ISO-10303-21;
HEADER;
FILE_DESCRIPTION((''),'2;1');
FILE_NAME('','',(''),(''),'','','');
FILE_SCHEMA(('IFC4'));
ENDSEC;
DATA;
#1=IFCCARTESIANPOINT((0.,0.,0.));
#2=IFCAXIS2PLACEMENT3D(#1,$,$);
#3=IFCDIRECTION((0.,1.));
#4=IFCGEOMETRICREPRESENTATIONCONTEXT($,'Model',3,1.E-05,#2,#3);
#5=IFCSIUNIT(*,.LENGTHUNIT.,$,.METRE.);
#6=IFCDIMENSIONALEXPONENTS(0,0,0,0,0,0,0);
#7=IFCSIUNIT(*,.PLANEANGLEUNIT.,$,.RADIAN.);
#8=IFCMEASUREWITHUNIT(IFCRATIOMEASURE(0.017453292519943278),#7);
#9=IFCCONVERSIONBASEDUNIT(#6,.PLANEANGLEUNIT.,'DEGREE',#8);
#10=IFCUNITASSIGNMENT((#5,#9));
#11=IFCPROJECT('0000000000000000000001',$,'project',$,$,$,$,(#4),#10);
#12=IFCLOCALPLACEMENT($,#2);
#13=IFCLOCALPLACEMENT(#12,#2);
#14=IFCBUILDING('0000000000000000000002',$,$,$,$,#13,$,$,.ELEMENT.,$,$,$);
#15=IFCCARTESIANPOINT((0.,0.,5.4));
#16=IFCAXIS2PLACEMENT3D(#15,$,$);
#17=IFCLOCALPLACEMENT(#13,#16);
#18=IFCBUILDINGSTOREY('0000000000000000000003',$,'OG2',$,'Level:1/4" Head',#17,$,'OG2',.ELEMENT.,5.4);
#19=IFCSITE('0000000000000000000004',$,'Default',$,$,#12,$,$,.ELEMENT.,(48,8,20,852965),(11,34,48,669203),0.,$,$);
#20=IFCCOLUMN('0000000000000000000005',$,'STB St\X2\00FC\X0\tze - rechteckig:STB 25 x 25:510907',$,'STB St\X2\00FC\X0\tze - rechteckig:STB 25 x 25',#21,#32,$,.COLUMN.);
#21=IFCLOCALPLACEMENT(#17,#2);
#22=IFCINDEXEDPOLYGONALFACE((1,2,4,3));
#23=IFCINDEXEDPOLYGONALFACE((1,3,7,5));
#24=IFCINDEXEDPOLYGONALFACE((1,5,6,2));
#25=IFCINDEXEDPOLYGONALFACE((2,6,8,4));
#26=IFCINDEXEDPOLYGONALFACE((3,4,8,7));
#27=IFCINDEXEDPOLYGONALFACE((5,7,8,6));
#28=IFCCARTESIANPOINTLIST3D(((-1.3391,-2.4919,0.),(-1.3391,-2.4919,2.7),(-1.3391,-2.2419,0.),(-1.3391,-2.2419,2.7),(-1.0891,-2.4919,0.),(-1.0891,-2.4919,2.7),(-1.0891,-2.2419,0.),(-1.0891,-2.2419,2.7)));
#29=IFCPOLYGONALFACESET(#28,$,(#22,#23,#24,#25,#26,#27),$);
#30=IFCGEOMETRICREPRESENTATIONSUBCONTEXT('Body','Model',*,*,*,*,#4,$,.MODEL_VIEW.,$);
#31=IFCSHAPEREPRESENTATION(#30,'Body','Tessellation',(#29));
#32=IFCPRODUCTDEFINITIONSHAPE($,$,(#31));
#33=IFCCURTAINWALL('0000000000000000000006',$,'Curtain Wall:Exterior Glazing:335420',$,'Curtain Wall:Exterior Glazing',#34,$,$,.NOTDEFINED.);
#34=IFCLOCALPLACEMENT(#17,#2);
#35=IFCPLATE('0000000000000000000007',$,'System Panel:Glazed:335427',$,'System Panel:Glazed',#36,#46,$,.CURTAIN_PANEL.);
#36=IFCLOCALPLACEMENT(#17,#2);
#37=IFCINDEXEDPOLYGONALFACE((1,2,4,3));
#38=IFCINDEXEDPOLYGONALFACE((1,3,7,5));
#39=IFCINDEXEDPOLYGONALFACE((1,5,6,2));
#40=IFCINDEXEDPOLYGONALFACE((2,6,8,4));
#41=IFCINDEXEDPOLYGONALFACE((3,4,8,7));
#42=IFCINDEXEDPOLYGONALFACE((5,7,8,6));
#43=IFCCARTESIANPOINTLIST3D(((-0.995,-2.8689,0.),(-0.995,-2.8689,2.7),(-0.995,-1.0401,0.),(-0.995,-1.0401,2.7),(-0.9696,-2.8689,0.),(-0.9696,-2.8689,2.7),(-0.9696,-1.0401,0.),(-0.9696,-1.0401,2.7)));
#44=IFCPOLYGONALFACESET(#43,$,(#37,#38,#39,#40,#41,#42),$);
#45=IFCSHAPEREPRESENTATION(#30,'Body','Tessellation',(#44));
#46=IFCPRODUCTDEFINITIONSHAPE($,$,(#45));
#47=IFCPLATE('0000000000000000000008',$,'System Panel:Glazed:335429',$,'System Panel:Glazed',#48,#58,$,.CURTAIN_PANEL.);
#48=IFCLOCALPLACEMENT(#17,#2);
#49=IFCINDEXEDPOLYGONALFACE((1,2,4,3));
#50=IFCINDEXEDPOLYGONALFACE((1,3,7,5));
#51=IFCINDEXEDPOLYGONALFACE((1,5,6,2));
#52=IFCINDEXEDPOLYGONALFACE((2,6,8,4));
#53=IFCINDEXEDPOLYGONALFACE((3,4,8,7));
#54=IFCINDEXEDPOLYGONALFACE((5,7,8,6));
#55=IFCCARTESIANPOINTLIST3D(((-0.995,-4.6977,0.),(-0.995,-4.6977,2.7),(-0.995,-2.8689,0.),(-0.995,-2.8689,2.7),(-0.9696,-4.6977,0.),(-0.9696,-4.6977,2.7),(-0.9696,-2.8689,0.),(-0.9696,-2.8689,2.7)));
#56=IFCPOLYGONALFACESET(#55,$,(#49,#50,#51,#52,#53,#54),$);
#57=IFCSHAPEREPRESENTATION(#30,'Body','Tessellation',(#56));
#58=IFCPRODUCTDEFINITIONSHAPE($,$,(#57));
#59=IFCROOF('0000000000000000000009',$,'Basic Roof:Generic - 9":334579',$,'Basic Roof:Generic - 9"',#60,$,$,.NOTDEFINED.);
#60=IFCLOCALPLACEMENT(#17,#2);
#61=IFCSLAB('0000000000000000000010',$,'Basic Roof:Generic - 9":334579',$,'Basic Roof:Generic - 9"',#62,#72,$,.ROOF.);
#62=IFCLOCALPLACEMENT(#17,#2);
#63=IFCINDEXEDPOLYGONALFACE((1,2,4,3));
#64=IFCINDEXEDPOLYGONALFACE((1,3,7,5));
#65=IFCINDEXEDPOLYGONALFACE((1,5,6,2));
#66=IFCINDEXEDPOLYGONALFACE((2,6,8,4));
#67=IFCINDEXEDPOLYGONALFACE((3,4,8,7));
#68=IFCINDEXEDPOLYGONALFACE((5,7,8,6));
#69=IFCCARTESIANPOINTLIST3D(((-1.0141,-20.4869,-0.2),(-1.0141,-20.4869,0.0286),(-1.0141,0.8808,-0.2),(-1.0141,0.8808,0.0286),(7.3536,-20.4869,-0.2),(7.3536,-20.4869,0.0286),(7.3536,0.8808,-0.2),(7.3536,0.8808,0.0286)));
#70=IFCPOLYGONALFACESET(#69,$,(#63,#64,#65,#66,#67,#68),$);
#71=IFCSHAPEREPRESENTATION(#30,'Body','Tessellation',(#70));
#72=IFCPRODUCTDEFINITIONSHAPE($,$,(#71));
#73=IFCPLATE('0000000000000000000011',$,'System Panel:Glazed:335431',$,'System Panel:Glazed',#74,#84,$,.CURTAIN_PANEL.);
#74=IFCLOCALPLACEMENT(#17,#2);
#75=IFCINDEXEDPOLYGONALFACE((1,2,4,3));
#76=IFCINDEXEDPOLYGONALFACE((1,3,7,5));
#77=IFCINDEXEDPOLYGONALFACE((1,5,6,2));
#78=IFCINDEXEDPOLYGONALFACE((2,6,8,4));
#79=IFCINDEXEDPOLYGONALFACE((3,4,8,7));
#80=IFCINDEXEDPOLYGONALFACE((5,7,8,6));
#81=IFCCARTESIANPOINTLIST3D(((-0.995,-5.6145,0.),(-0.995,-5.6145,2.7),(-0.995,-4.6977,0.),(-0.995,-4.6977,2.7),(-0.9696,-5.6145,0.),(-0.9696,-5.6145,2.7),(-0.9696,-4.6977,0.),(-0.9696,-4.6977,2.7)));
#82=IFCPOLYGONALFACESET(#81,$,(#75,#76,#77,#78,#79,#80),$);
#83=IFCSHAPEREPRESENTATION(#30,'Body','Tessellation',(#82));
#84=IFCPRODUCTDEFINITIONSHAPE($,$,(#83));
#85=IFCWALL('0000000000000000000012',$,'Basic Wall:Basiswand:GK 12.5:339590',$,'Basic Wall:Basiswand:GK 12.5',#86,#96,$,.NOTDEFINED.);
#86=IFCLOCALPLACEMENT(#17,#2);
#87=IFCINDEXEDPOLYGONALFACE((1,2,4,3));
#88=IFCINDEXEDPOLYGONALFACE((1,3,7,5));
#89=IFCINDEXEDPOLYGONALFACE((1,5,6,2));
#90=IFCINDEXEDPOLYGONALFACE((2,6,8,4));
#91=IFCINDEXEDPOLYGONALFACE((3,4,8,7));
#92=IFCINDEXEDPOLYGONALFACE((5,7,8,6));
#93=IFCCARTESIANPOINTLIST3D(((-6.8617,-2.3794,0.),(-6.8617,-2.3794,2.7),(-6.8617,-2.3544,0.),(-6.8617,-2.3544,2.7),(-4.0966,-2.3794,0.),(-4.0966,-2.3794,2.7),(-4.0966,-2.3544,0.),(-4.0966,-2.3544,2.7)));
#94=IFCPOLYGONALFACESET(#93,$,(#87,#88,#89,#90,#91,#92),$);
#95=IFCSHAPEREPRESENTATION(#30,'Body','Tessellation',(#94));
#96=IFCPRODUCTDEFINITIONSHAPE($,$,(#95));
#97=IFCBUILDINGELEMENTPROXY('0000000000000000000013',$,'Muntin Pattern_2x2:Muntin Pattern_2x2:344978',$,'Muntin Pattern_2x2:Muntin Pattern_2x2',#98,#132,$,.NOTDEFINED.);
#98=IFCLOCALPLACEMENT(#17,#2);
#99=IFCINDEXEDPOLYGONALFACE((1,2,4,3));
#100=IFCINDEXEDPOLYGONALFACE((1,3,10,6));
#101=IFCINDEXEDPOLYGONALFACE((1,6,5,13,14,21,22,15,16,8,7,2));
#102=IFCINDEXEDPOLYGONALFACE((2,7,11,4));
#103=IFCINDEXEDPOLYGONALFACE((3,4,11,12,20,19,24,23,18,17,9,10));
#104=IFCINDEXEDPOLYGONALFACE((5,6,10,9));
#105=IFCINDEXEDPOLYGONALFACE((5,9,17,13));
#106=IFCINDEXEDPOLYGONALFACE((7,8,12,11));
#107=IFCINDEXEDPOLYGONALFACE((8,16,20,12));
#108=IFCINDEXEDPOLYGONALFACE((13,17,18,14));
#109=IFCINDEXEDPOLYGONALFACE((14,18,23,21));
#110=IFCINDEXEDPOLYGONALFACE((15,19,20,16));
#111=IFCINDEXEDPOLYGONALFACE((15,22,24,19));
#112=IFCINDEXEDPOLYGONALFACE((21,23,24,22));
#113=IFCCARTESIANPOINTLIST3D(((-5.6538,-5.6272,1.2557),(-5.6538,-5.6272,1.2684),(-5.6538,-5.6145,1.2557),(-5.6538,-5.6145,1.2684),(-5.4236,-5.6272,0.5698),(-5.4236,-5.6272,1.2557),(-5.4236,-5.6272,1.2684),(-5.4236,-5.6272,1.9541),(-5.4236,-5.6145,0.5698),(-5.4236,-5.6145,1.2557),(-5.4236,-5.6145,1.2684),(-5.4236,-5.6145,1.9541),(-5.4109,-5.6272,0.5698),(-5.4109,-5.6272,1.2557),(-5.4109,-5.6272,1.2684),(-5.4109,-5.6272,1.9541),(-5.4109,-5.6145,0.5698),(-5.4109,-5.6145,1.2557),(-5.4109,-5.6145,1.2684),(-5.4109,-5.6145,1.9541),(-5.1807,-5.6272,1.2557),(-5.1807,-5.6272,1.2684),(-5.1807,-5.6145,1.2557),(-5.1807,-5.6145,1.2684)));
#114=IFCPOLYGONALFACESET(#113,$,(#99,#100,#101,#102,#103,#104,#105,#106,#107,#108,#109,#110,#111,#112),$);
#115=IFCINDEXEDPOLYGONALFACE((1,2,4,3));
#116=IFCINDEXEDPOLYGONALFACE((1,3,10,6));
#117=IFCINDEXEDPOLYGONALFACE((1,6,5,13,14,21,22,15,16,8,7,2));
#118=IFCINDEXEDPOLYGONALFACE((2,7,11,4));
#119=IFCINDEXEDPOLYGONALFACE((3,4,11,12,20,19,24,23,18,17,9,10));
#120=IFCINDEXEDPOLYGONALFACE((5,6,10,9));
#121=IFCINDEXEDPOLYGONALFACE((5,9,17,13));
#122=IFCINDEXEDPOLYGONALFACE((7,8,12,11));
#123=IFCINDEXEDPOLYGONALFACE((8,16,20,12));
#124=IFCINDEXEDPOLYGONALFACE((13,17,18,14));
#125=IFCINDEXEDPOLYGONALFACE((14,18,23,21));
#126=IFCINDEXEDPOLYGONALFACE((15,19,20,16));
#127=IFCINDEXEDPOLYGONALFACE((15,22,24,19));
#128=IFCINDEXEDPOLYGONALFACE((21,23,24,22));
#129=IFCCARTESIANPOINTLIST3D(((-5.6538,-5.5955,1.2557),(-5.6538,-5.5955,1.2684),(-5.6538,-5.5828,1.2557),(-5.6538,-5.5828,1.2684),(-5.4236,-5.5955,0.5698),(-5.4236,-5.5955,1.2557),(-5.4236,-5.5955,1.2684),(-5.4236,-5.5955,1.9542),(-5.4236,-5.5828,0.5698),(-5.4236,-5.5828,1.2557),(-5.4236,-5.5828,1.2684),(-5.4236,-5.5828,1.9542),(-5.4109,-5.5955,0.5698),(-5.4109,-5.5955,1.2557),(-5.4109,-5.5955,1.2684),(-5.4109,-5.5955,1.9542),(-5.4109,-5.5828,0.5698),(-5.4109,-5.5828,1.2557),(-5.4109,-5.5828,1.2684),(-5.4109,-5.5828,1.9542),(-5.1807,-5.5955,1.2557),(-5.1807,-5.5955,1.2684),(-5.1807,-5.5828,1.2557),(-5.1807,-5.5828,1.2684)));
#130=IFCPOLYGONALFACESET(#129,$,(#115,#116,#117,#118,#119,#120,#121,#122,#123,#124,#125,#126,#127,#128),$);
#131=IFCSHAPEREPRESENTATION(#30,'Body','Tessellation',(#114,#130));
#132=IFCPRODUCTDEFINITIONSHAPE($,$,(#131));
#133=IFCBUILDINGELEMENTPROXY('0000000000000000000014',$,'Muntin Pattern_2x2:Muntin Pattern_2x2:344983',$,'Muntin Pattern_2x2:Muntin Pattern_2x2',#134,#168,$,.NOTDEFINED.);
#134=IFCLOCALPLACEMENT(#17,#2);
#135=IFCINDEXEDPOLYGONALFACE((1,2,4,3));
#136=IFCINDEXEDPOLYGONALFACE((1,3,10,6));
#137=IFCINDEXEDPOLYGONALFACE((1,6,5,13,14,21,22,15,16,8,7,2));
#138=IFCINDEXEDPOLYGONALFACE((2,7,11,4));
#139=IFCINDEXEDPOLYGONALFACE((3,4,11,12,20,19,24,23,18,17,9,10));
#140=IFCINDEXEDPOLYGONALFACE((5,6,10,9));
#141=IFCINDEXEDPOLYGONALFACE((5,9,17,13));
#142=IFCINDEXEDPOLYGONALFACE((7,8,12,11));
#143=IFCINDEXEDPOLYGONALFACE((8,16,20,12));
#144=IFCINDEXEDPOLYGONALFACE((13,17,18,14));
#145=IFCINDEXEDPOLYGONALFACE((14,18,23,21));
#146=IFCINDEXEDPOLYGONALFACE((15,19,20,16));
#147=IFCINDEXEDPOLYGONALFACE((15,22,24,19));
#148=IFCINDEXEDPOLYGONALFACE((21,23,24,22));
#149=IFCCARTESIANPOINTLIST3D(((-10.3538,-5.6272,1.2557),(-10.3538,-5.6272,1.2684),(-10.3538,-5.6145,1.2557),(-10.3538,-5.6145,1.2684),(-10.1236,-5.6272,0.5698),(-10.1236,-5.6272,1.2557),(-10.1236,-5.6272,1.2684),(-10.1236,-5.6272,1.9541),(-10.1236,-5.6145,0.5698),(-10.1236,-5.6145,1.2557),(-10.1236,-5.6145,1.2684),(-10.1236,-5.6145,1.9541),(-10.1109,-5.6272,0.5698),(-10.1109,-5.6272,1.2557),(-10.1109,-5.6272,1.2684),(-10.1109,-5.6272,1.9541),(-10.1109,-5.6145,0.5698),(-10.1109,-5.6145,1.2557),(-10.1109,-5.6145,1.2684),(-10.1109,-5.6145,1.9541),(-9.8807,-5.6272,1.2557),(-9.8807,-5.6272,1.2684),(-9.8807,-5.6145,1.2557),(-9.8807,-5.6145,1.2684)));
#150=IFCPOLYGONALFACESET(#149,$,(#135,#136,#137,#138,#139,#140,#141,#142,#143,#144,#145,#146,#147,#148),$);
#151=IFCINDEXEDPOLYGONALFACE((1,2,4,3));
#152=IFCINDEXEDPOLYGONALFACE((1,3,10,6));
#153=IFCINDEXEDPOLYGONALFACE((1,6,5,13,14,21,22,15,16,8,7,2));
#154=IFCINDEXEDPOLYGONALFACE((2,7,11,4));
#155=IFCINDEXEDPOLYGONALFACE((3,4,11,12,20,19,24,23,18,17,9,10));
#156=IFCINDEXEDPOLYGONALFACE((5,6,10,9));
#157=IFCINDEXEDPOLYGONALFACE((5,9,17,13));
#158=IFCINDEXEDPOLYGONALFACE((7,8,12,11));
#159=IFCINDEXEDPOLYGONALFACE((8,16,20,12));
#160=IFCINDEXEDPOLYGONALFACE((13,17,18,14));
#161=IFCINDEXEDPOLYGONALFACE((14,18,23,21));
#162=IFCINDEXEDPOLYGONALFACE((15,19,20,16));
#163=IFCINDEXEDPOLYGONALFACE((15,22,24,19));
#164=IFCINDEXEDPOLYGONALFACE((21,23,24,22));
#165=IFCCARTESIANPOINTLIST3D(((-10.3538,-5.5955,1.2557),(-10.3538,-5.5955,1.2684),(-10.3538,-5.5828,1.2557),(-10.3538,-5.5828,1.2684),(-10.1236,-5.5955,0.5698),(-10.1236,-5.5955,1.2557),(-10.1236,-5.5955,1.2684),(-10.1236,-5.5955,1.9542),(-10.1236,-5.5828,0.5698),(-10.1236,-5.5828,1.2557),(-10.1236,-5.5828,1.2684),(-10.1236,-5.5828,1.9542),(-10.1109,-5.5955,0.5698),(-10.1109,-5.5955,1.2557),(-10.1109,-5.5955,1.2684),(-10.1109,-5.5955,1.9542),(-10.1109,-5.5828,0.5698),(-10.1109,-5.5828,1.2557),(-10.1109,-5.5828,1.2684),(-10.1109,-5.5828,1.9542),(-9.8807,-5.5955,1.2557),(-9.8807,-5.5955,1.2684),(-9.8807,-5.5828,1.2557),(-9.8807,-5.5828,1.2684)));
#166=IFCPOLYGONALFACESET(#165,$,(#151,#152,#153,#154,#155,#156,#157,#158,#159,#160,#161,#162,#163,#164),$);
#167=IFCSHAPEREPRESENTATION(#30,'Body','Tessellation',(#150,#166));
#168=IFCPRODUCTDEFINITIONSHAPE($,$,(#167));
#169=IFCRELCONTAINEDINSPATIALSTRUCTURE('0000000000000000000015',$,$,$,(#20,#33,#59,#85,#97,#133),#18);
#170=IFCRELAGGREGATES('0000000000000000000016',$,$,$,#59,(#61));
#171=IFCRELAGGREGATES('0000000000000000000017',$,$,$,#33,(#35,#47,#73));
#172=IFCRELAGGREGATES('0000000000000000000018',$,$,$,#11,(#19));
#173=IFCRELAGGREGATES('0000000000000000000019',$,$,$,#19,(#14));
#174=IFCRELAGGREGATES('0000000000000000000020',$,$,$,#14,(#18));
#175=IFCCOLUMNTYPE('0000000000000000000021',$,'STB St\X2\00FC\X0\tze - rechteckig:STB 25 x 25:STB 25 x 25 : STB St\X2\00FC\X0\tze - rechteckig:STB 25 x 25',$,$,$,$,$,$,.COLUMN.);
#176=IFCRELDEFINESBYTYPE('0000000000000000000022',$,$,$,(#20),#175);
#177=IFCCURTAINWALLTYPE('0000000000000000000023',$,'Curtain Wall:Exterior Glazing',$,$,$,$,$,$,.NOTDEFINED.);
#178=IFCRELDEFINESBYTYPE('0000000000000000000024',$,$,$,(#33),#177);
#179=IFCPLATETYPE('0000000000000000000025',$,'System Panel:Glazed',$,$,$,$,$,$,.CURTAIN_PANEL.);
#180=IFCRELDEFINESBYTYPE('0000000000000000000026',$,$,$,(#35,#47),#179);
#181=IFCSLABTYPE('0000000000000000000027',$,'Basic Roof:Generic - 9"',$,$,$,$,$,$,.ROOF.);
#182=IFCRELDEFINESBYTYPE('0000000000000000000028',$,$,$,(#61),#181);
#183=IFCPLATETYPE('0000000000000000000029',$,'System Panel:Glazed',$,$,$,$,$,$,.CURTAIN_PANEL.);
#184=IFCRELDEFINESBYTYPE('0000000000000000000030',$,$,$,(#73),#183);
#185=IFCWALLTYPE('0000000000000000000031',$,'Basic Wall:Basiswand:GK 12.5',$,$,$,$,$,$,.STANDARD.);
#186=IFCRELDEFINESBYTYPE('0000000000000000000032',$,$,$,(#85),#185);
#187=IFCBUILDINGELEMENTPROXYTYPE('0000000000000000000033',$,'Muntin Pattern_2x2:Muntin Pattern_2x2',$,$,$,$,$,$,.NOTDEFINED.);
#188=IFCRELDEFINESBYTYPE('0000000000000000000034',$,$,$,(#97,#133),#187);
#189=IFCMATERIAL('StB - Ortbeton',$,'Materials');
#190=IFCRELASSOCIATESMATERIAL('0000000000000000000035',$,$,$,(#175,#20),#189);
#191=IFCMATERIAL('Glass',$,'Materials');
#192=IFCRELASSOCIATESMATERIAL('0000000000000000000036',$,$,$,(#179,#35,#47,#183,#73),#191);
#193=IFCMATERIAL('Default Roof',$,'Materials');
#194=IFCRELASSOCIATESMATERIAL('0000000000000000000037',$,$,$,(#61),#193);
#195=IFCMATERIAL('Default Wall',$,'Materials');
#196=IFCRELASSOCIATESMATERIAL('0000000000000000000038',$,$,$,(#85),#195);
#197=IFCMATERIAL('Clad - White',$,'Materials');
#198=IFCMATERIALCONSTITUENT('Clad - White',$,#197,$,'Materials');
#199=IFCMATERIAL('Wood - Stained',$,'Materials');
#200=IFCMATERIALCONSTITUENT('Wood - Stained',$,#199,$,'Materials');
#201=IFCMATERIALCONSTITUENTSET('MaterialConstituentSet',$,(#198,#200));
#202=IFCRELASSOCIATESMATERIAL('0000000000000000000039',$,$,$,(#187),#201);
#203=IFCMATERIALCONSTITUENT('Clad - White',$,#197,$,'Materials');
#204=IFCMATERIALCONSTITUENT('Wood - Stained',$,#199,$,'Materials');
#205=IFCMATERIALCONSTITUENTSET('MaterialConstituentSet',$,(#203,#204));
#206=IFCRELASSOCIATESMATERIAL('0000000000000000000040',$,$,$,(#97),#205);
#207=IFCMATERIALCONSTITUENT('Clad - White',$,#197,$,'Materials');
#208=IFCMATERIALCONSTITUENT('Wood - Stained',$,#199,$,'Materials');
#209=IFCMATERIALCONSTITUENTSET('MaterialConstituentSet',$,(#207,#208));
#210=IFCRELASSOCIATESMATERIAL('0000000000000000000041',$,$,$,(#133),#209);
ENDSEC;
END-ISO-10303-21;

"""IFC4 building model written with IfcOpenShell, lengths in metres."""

from ifc_helpers import new_model, entity, si_unit, converted_unit, direction, frame, origin, place, context, subcontext, project, spatial, indexed_curve, outline, extrude, source, transform, mapped, material, constituent, constituent_set, type_object, type_shapes, element, aggregate, save


model = new_model("IFC4")

# Units and contexts
model_context = context("Model", 3, precision=1e-05, world=origin(), true_north=direction((0.0, 1.0)))
body_context = subcontext(model_context, "Body", "Model", "MODEL_VIEW")
ifc_project = project(units=[si_unit("LENGTHUNIT", "METRE"), converted_unit("PLANEANGLEUNIT", "DEGREE", entity("IfcRatioMeasure", 0.017453292519943278), si_unit("PLANEANGLEUNIT", "RADIAN"), dimensions=[0, 0, 0, 0, 0, 0, 0])], contexts=[model_context])

# Site, building, storey
site_placement = place(None, origin())
site = spatial("IfcSite", under=ifc_project, at=site_placement, Name="Default", CompositionType="ELEMENT", RefLatitude=(48, 8, 20, 852965), RefLongitude=(11, 34, 48, 669203), RefElevation=0.0)
building_placement = place(site_placement, origin())
building = spatial("IfcBuilding", under=site, at=building_placement, CompositionType="ELEMENT")
storey_placement = place(building_placement, frame((0.0, 0.0, 5.4)))
storey = spatial("IfcBuildingStorey", under=building, at=storey_placement, Name="OG2", ObjectType="Level:1/4\" Head", LongName="OG2", CompositionType="ELEMENT", Elevation=5.4)

# Column
ifc_material_1 = material(Name="StB - Ortbeton", Category="Materials")
column_type = type_object("IfcColumnType", Name="STB Stütze - rechteckig:STB 25 x 25:STB 25 x 25 : STB Stütze - rechteckig:STB 25 x 25", PredefinedType="COLUMN", material=ifc_material_1)
shared_shape_1 = source(origin(), body_context, "Body", "SweptSolid", [
    extrude(outline(indexed_curve([(-0.125, -0.125), (0.125, -0.125), (0.125, 0.125), (-0.125, 0.125), (-0.125, -0.125)], self_intersect=False)), frame((0.0, 0.0, 5.4), z_axis=(0.0, 0.0, 1.0), x_axis=(0.0, -1.0, 0.0)), (0.0, 0.0, 1.0), 2.7),
])
type_shapes(column_type, [shared_shape_1])
column_placement = place(storey_placement, frame((-1.2141, -2.3669, -5.4)))
element("IfcColumn", 1, at=column_placement, inside=storey, type_object=column_type, material=ifc_material_1, Name="STB Stütze - rechteckig:STB 25 x 25:510907", ObjectType="STB Stütze - rechteckig:STB 25 x 25", PredefinedType="COLUMN", context=body_context, shape_type="MappedRepresentation", body=[
    mapped(shared_shape_1, transform((0.0, 0.0, 0.0), scale=1.0)),
])

# Curtain wall, plates
curtain_wall_type = type_object("IfcCurtainWallType", Name="Curtain Wall:Exterior Glazing", PredefinedType="NOTDEFINED")
curtain_wall_placement = place(storey_placement, frame((0.0, 0.0, -5.4)))
curtain_wall = element("IfcCurtainWall", 2, at=curtain_wall_placement, inside=storey, type_object=curtain_wall_type, Name="Curtain Wall:Exterior Glazing:335420", ObjectType="Curtain Wall:Exterior Glazing", PredefinedType="NOTDEFINED")
ifc_material_2 = material(Name="Glass", Category="Materials")
plate_type_1 = type_object("IfcPlateType", Name="System Panel:Glazed", PredefinedType="CURTAIN_PANEL", material=ifc_material_2)
shared_shape_2 = source(origin(), body_context, "Body", "SweptSolid", [
    extrude(outline(indexed_curve([(-0.0127, -0.9144), (0.0127, -0.9144), (0.0127, 0.9144), (-0.0127, 0.9144), (-0.0127, -0.9144)], self_intersect=False)), frame((0.0, 0.0317, 0.0), z_axis=(0.0, 0.0, 1.0), x_axis=(0.0, 1.0, 0.0)), (0.0, 0.0, 1.0), 2.7),
])
type_shapes(plate_type_1, [shared_shape_2])
plate_1_placement = place(curtain_wall_placement, frame((-1.0141, -1.9545, 5.4), z_axis=(0.0, 0.0, 1.0), x_axis=(0.0, -1.0, 0.0)))
plate_1 = element("IfcPlate", 3, at=plate_1_placement, type_object=plate_type_1, material=ifc_material_2, Name="System Panel:Glazed:335427", ObjectType="System Panel:Glazed", PredefinedType="CURTAIN_PANEL", context=body_context, shape_type="MappedRepresentation", body=[
    mapped(shared_shape_2, transform((0.0, 0.0, 0.0), scale=1.0)),
])
plate_2_placement = place(curtain_wall_placement, frame((-1.0141, -3.7833, 5.4), z_axis=(0.0, 0.0, 1.0), x_axis=(0.0, -1.0, 0.0)))
plate_2 = element("IfcPlate", 4, at=plate_2_placement, type_object=plate_type_1, material=ifc_material_2, Name="System Panel:Glazed:335429", ObjectType="System Panel:Glazed", PredefinedType="CURTAIN_PANEL", context=body_context, shape_type="MappedRepresentation", body=[
    mapped(shared_shape_2, transform((0.0, 0.0, 0.0), scale=1.0)),
])

# Roof, slab
roof_placement = place(storey_placement, frame((-1.0141, -20.4869, -0.2)))
roof = element("IfcRoof", 5, at=roof_placement, inside=storey, Name="Basic Roof:Generic - 9\":334579", ObjectType="Basic Roof:Generic - 9\"", PredefinedType="NOTDEFINED")
ifc_material_3 = material(Name="Default Roof", Category="Materials")
slab_type = type_object("IfcSlabType", Name="Basic Roof:Generic - 9\"", PredefinedType="ROOF")
slab_placement = place(roof_placement, origin())
slab = element("IfcSlab", 6, at=slab_placement, type_object=slab_type, material=ifc_material_3, Name="Basic Roof:Generic - 9\":334579", ObjectType="Basic Roof:Generic - 9\"", PredefinedType="ROOF", context=body_context, shape_type="SweptSolid", body=[
    extrude(outline(indexed_curve([(-4.1838, 10.6838), (-4.1838, -10.6838), (4.1838, -10.6838), (4.1838, 10.6838), (-4.1838, 10.6838)], self_intersect=False)), frame((4.1838, 10.6838, 0.0)), (0.0, 0.0, 1.0), 0.2286),
])
aggregate(roof, [slab])

# Plate
plate_type_2 = type_object("IfcPlateType", Name="System Panel:Glazed", PredefinedType="CURTAIN_PANEL", material=ifc_material_2)
shared_shape_3 = source(origin(), body_context, "Body", "SweptSolid", [
    extrude(outline(indexed_curve([(-0.0127, -0.4584), (0.0127, -0.4584), (0.0127, 0.4584), (-0.0127, 0.4584), (-0.0127, -0.4584)], self_intersect=False)), frame((0.0, 0.0318, 0.0), z_axis=(0.0, 0.0, 1.0), x_axis=(0.0, 1.0, 0.0)), (0.0, 0.0, 1.0), 2.7),
])
type_shapes(plate_type_2, [shared_shape_3])
plate_3_placement = place(curtain_wall_placement, frame((-1.0141, -5.1561, 5.4), z_axis=(0.0, 0.0, 1.0), x_axis=(0.0, -1.0, 0.0)))
plate_3 = element("IfcPlate", 7, at=plate_3_placement, type_object=plate_type_2, material=ifc_material_2, Name="System Panel:Glazed:335431", ObjectType="System Panel:Glazed", PredefinedType="CURTAIN_PANEL", context=body_context, shape_type="MappedRepresentation", body=[
    mapped(shared_shape_3, transform((0.0, 0.0, 0.0), scale=1.0)),
])
aggregate(curtain_wall, [plate_1, plate_2, plate_3])

# Wall
ifc_material_4 = material(Name="Default Wall", Category="Materials")
wall_type_1 = type_object("IfcWallType", Name="Basic Wall:Basiswand:GK 12.5", PredefinedType="STANDARD")
wall_1_placement = place(storey_placement, frame((-6.8617, -2.3669, 0.0)))
element("IfcWall", 8, at=wall_1_placement, inside=storey, type_object=wall_type_1, material=ifc_material_4, Name="Basic Wall:Basiswand:GK 12.5:339590", ObjectType="Basic Wall:Basiswand:GK 12.5", PredefinedType="NOTDEFINED", context=body_context, shape_type="SweptSolid", body=[
    extrude(outline(indexed_curve([(2.7651, 0.0125), (0.0, 0.0125), (0.0, -0.0125), (2.7651, -0.0125), (2.7651, 0.0125)], self_intersect=False)), origin(), (0.0, 0.0, 1.0), 2.7),
])

# Building element proxies
ifc_material_5 = material(Name="Clad - White", Category="Materials")
ifc_constituent_1 = constituent(ifc_material_5, Name="Clad - White", Category="Materials")
ifc_material_6 = material(Name="Wood - Stained", Category="Materials")
ifc_constituent_2 = constituent(ifc_material_6, Name="Wood - Stained", Category="Materials")
ifc_constituent_set_1 = constituent_set(constituents=[ifc_constituent_1, ifc_constituent_2], Name="MaterialConstituentSet")
ifc_constituent_3 = constituent(ifc_material_5, Name="Clad - White", Category="Materials")
ifc_constituent_4 = constituent(ifc_material_6, Name="Wood - Stained", Category="Materials")
ifc_constituent_set_2 = constituent_set(constituents=[ifc_constituent_3, ifc_constituent_4], Name="MaterialConstituentSet")
building_element_proxy_type_1 = type_object("IfcBuildingElementProxyType", Name="Muntin Pattern_2x2:Muntin Pattern_2x2", PredefinedType="NOTDEFINED", material=ifc_constituent_set_2)
shared_shape_4 = source(origin(), body_context, "Body", "SweptSolid", [
    extrude(outline(indexed_curve([(0.0064, -0.0064), (0.6921, -0.0064), (0.6921, 0.0063), (0.0064, 0.0063), (0.0064, 0.2365), (-0.0063, 0.2365), (-0.0063, 0.0063), (-0.6922, 0.0063), (-0.6922, -0.0064), (-0.0063, -0.0064), (-0.0063, -0.2365), (0.0064, -0.2365), (0.0064, -0.0064)], self_intersect=False)), frame((0.0, -0.0222, 0.6921), z_axis=(0.0, 1.0, 0.0), x_axis=(0.0, 0.0, 1.0)), (0.0, 0.0, 1.0), 0.0127),
    extrude(outline(indexed_curve([(0.0064, -0.0064), (0.6922, -0.0064), (0.6922, 0.0063), (0.0064, 0.0063), (0.0064, 0.2365), (-0.0063, 0.2365), (-0.0063, 0.0063), (-0.6922, 0.0063), (-0.6922, -0.0064), (-0.0063, -0.0064), (-0.0063, -0.2365), (0.0064, -0.2365), (0.0064, -0.0064)], self_intersect=False)), frame((0.0, 0.0095, 0.6922), z_axis=(0.0, 1.0, 0.0), x_axis=(0.0, 0.0, 1.0)), (0.0, 0.0, 1.0), 0.0127),
])
type_shapes(building_element_proxy_type_1, [shared_shape_4])
proxy_1_placement = place(storey_placement, frame((-5.4173, -5.605, 0.5699)))
element("IfcBuildingElementProxy", 9, at=proxy_1_placement, inside=storey, type_object=building_element_proxy_type_1, material=ifc_constituent_set_1, Name="Muntin Pattern_2x2:Muntin Pattern_2x2:344978", ObjectType="Muntin Pattern_2x2:Muntin Pattern_2x2", PredefinedType="NOTDEFINED", context=body_context, shape_type="MappedRepresentation", body=[
    mapped(shared_shape_4, transform((0.0, 0.0, 0.0), scale=1.0)),
])
ifc_constituent_5 = constituent(ifc_material_5, Name="Clad - White", Category="Materials")
ifc_constituent_6 = constituent(ifc_material_6, Name="Wood - Stained", Category="Materials")
ifc_constituent_set_3 = constituent_set(constituents=[ifc_constituent_5, ifc_constituent_6], Name="MaterialConstituentSet")
proxy_2_placement = place(storey_placement, frame((-10.1173, -5.605, 0.5699)))
element("IfcBuildingElementProxy", 10, at=proxy_2_placement, inside=storey, type_object=building_element_proxy_type_1, material=ifc_constituent_set_3, Name="Muntin Pattern_2x2:Muntin Pattern_2x2:344983", ObjectType="Muntin Pattern_2x2:Muntin Pattern_2x2", PredefinedType="NOTDEFINED", context=body_context, shape_type="MappedRepresentation", body=[
    mapped(shared_shape_4, transform((0.0, 0.0, 0.0), scale=1.0)),
])

save(model, "model.ifc")
